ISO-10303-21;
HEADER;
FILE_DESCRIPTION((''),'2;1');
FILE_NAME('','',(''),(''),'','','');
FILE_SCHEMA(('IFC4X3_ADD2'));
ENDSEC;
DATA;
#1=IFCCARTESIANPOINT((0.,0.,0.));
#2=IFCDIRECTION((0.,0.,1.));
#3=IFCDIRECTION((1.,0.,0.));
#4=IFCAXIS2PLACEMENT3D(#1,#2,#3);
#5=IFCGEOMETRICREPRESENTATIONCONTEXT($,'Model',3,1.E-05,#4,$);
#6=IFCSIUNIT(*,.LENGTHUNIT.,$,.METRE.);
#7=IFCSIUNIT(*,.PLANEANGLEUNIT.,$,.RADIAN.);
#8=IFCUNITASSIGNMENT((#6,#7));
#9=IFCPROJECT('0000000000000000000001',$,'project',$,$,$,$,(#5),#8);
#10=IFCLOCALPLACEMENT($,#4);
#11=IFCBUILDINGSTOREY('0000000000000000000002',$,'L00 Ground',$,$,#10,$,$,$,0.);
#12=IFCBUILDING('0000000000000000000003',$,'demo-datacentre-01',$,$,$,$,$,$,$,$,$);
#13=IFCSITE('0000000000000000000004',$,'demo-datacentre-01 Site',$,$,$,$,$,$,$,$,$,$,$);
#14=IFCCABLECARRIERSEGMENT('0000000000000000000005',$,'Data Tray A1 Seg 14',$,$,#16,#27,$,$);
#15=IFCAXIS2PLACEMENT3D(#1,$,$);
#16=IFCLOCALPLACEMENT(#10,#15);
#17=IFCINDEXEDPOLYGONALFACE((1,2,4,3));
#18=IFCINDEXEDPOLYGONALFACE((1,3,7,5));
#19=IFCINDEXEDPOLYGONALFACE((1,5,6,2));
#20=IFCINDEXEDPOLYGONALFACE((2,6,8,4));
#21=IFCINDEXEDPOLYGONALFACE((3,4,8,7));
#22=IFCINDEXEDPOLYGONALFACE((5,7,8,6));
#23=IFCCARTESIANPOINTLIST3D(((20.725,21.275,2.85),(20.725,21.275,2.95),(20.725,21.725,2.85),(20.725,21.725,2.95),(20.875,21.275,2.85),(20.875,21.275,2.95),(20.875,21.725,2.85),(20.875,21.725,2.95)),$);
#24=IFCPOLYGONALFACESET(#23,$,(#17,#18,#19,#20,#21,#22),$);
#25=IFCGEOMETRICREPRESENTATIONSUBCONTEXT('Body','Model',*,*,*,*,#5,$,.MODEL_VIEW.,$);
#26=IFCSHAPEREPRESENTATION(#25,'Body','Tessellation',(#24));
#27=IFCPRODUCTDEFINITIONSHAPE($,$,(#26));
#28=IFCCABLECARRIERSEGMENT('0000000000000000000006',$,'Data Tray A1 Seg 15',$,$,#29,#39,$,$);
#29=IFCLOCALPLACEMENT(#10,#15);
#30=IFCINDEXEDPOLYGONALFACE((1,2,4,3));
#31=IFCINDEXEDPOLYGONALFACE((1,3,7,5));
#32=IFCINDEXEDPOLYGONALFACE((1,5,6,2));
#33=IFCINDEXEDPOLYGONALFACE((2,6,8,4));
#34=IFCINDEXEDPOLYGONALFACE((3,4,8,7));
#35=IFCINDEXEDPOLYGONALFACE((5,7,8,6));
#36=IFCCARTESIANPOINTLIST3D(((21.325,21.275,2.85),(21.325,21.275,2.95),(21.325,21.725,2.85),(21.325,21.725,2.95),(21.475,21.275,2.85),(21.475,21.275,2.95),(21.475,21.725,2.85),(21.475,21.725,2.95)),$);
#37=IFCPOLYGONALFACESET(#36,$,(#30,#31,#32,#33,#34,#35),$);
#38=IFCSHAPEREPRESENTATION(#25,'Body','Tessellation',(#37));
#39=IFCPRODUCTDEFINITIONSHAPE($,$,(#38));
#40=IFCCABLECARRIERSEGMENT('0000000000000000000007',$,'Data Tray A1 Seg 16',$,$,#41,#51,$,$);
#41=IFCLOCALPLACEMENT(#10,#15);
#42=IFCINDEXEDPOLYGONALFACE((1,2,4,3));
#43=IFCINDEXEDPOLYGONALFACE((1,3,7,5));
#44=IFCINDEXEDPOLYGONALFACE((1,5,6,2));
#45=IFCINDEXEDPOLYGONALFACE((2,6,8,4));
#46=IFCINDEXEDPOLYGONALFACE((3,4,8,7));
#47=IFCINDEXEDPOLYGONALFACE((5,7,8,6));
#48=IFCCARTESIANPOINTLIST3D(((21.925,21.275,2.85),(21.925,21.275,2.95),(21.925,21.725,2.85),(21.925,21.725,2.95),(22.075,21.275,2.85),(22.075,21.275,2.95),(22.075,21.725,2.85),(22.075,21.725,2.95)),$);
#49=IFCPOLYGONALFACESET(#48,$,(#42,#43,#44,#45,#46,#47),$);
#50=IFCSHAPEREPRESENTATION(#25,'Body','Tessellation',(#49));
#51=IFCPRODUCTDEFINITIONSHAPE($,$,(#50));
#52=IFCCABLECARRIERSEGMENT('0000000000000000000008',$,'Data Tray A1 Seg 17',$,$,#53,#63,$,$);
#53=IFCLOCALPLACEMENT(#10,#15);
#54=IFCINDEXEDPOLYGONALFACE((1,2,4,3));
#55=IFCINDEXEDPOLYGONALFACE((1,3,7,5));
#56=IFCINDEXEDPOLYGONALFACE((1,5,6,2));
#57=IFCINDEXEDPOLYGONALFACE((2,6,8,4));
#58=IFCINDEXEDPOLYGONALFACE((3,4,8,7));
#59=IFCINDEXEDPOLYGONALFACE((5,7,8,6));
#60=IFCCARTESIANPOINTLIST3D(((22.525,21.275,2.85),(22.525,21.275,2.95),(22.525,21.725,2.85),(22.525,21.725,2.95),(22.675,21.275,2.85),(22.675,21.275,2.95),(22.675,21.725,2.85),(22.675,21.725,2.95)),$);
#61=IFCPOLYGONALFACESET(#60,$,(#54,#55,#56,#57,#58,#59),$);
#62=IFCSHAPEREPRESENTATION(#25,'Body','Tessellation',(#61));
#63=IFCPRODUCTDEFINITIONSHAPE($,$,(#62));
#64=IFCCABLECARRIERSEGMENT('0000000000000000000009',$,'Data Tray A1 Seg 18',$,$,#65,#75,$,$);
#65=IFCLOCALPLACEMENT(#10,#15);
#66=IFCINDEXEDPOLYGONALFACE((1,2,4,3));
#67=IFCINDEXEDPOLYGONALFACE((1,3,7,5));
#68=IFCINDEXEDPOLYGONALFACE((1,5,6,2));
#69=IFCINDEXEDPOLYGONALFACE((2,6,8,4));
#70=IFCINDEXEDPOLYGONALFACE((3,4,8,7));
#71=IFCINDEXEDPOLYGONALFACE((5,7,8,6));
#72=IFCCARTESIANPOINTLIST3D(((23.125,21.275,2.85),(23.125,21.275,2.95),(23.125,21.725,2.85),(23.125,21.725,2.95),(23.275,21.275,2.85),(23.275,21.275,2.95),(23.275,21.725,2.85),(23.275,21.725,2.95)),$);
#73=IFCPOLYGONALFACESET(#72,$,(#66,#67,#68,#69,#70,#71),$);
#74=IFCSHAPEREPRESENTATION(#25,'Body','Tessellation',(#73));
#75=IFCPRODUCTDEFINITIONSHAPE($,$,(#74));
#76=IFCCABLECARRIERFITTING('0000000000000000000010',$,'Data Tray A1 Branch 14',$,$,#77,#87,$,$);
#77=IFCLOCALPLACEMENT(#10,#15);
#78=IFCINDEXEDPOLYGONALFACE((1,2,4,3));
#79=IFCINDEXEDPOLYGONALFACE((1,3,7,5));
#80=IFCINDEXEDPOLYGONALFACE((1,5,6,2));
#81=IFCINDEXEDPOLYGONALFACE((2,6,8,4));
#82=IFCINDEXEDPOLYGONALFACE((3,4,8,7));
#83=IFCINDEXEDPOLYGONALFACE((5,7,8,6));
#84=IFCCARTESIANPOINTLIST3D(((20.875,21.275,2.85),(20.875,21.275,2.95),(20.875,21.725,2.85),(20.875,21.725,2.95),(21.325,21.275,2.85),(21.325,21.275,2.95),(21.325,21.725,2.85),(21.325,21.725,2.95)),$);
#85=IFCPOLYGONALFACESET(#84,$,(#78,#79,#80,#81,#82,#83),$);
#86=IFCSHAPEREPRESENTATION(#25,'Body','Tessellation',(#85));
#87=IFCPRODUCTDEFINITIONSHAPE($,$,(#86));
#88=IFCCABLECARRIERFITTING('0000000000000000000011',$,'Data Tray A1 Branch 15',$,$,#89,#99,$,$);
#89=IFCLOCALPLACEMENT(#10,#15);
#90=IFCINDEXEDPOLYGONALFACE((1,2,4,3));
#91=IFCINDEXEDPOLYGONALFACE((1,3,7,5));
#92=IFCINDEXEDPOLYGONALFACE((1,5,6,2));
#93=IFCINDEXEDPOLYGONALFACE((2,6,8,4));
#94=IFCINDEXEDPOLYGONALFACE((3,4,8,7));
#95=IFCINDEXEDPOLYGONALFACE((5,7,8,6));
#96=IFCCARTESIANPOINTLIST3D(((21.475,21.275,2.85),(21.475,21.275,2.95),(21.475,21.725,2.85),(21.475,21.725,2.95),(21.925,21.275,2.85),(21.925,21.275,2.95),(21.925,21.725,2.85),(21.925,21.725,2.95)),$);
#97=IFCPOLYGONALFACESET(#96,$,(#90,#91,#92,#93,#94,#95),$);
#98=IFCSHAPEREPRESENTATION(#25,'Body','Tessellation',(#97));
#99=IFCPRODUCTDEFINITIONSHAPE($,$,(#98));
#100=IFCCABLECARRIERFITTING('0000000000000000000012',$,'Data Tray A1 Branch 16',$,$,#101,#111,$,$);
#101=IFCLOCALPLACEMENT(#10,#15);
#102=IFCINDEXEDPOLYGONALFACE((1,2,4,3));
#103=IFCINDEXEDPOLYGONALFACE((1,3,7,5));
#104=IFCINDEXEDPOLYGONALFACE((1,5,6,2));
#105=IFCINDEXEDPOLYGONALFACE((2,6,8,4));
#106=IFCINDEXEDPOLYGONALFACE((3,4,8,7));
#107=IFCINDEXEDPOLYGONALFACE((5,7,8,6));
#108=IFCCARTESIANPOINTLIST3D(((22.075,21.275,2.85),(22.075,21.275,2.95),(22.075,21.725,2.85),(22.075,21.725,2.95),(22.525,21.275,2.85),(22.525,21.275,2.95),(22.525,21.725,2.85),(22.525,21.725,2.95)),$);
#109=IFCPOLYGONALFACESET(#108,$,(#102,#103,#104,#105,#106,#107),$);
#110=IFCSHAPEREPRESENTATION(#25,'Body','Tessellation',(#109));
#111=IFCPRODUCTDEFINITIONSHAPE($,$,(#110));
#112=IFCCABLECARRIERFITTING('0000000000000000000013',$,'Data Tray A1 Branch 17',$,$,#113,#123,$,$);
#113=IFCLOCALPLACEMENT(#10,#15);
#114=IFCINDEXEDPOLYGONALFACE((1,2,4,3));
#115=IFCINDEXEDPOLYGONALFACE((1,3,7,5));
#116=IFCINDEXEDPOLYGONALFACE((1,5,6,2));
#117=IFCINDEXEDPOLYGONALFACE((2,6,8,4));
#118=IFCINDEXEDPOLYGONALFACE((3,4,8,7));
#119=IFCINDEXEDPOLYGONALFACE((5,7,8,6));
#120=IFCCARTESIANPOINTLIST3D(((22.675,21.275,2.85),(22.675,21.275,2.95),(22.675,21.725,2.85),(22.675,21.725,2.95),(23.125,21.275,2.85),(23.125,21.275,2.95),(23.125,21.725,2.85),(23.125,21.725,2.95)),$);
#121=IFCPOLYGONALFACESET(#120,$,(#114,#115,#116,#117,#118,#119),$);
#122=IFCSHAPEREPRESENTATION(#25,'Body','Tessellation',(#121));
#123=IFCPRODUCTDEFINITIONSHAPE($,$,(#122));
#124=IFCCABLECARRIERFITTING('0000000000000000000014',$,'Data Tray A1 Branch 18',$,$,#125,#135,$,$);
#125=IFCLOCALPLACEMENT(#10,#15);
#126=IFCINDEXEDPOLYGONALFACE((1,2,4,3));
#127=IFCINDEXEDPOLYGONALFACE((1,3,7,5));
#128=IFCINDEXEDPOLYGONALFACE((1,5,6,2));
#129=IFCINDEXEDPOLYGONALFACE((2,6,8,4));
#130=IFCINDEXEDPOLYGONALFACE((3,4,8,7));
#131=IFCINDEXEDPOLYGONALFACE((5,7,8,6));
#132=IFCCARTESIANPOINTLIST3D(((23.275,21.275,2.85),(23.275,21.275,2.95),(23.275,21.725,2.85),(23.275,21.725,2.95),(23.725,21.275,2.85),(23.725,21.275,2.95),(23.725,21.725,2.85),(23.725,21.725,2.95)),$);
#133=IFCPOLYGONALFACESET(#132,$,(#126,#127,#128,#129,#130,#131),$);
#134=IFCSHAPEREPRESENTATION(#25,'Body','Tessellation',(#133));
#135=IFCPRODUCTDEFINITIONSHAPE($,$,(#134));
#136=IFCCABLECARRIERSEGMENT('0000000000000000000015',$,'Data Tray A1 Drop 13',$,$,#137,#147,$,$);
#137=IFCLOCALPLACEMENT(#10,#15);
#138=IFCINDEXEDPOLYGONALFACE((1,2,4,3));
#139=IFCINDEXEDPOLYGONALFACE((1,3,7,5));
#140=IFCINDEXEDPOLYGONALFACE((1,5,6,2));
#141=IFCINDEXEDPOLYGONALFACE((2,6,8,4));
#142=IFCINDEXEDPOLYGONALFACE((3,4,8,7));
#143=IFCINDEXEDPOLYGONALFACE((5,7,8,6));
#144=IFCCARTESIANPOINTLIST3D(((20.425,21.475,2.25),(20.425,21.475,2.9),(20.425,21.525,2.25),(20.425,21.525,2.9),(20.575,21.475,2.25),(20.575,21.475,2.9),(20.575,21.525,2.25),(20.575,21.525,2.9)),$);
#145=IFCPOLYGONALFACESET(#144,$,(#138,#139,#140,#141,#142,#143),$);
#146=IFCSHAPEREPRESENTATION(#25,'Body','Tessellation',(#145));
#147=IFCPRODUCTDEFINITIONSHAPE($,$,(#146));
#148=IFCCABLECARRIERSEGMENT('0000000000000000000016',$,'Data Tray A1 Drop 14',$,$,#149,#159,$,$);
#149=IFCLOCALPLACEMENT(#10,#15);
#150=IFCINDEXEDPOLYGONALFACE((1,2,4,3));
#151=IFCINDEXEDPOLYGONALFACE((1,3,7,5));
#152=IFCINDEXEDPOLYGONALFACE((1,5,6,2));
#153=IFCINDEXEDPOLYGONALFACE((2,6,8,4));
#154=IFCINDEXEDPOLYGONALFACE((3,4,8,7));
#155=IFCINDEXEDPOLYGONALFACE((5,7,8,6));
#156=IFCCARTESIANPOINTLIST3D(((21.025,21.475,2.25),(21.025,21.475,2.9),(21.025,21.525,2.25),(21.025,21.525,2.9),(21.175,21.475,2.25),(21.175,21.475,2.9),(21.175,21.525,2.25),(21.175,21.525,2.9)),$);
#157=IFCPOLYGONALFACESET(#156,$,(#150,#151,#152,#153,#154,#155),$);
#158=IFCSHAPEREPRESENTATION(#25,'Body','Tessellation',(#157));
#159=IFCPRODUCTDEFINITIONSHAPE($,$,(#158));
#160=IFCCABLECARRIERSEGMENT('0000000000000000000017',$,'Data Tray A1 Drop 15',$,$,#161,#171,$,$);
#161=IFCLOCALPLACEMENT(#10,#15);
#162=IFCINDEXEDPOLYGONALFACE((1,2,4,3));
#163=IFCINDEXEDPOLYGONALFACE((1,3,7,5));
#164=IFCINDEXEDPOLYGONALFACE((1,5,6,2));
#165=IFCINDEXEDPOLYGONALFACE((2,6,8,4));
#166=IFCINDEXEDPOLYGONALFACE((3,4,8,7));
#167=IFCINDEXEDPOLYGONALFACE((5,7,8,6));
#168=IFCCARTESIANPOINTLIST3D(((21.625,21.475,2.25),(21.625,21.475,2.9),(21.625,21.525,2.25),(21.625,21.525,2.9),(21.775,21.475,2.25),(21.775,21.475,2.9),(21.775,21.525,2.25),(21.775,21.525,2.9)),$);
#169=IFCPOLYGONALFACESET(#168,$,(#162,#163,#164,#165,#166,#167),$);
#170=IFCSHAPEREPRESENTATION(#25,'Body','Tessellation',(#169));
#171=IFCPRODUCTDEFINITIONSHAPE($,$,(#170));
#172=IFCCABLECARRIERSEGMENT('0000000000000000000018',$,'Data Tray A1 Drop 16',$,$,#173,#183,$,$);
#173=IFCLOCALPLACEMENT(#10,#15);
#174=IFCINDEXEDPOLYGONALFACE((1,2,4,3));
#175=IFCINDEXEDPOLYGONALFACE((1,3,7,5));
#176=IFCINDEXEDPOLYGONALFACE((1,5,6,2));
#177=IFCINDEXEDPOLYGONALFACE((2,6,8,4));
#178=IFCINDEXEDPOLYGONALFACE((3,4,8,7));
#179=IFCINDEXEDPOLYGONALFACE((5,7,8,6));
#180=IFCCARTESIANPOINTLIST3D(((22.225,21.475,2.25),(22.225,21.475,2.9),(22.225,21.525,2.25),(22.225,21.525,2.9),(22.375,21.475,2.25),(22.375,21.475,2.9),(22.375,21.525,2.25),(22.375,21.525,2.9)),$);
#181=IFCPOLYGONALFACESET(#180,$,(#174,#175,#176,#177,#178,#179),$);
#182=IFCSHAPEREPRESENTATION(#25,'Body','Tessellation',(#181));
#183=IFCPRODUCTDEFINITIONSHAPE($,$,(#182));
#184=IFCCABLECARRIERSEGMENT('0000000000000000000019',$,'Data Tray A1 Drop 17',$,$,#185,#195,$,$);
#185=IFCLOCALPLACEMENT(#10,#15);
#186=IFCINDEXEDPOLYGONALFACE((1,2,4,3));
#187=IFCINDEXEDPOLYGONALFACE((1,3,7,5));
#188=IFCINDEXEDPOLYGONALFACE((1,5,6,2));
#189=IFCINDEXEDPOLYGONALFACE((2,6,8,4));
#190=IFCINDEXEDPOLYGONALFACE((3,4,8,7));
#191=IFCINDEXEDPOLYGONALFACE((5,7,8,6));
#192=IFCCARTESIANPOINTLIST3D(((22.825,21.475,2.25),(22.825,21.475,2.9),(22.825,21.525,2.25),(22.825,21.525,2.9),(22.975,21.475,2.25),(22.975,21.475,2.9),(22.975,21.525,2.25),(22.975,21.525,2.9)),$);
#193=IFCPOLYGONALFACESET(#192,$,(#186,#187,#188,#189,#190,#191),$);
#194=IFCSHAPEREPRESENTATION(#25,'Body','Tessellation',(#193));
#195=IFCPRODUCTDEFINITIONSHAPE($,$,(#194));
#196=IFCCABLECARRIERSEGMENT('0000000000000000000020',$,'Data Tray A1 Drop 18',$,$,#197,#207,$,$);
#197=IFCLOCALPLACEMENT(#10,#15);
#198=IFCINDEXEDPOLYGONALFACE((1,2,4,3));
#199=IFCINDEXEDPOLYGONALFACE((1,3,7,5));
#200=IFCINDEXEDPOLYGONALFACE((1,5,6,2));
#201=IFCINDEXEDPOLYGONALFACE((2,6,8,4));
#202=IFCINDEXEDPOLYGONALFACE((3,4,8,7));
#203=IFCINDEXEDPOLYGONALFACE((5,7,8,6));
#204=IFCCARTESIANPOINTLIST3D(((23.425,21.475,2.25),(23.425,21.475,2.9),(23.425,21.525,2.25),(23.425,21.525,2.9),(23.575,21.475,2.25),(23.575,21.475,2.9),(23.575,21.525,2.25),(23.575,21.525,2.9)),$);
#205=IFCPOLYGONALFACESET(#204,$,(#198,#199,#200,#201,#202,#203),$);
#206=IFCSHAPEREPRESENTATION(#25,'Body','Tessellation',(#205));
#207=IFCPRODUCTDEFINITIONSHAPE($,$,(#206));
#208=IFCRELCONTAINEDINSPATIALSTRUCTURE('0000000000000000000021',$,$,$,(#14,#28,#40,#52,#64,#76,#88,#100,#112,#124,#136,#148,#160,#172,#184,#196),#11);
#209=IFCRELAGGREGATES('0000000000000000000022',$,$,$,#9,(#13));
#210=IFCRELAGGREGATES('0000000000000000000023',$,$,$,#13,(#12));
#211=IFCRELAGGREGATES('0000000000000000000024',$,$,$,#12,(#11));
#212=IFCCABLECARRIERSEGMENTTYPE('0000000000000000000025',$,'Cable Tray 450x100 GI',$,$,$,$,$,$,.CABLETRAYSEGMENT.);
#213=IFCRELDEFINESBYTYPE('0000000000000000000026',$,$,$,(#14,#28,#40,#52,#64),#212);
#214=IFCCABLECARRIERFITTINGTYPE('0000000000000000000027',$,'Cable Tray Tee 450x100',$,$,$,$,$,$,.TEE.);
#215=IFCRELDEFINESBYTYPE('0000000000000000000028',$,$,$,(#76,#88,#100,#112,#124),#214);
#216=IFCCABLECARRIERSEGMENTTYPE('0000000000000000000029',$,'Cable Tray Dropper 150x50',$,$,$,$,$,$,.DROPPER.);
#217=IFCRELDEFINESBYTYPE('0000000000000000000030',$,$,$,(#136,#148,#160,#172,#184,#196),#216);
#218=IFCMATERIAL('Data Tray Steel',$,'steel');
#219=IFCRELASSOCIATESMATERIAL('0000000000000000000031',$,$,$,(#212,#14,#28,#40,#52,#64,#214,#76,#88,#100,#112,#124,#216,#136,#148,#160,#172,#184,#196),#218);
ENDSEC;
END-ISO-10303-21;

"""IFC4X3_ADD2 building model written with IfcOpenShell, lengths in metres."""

from ifc_helpers import new_model, si_unit, frame, origin_with_axes, place, context, subcontext, project, spatial, rectangle, extrude, material, type_object, element, save


model = new_model("IFC4X3_ADD2")

# Units and contexts
model_context = context("Model", 3, precision=1e-05, world=origin_with_axes())
body_context = subcontext(model_context, "Body", "Model", "MODEL_VIEW")
ifc_project = project(units=[si_unit("LENGTHUNIT", "METRE"), si_unit("PLANEANGLEUNIT", "RADIAN")], contexts=[model_context])

# Site, building, storey
site = spatial("IfcSite", under=ifc_project, Name="demo-datacentre-01 Site")
building = spatial("IfcBuilding", under=site, Name="demo-datacentre-01")
storey_placement = place(None, origin_with_axes())
storey = spatial("IfcBuildingStorey", under=building, at=storey_placement, Name="L00 Ground", Elevation=0.0)

# Cable carrier segments
ifc_material_1 = material(Name="Data Tray Steel", Category="steel")
cable_carrier_segment_type_1 = type_object("IfcCableCarrierSegmentType", Name="Cable Tray 450x100 GI", PredefinedType="CABLETRAYSEGMENT", material=ifc_material_1)
for number, where, z_axis, x_axis, name in (
    (1, (20.725, 21.5, 2.9), (1.0, 0.0, 0.0), (0.0, 1.0, 0.0), "Data Tray A1 Seg 14"),
    (2, (21.325, 21.5, 2.9), (1.0, 0.0, 0.0), (0.0, 1.0, 0.0), "Data Tray A1 Seg 15"),
):
    element("IfcCableCarrierSegment", number, at=place(storey_placement, frame(where, z_axis=z_axis, x_axis=x_axis)), inside=storey, type_object=cable_carrier_segment_type_1, material=ifc_material_1, Name=name, context=body_context, shape_type="SweptSolid", body=[
        extrude(rectangle(XDim=0.45, YDim=0.1), origin_with_axes(), (0.0, 0.0, 1.0), 0.15),
    ])
for number, where, z_axis, x_axis, name in (
    (3, (21.925, 21.5, 2.9), (1.0, 0.0, 0.0), (0.0, 1.0, 0.0), "Data Tray A1 Seg 16"),
    (4, (22.525, 21.5, 2.9), (1.0, 0.0, 0.0), (0.0, 1.0, 0.0), "Data Tray A1 Seg 17"),
):
    element("IfcCableCarrierSegment", number, at=place(storey_placement, frame(where, z_axis=z_axis, x_axis=x_axis)), inside=storey, type_object=cable_carrier_segment_type_1, material=ifc_material_1, Name=name, context=body_context, shape_type="SweptSolid", body=[
        extrude(rectangle(XDim=0.45, YDim=0.1), origin_with_axes(), (0.0, 0.0, 1.0), 0.15),
    ])
cable_carrier_segment_placement = place(storey_placement, frame((23.125, 21.5, 2.9), z_axis=(1.0, 0.0, 0.0), x_axis=(0.0, 1.0, 0.0)))
element("IfcCableCarrierSegment", 5, at=cable_carrier_segment_placement, inside=storey, type_object=cable_carrier_segment_type_1, material=ifc_material_1, Name="Data Tray A1 Seg 18", context=body_context, shape_type="SweptSolid", body=[
    extrude(rectangle(XDim=0.45, YDim=0.1), origin_with_axes(), (0.0, 0.0, 1.0), 0.15),
])

# Cable carrier fittings
cable_carrier_fitting_type = type_object("IfcCableCarrierFittingType", Name="Cable Tray Tee 450x100", PredefinedType="TEE", material=ifc_material_1)
for number, where, z_axis, x_axis, name in (
    (6, (21.1, 21.5, 2.85), (0.0, 0.0, 1.0), (1.0, 0.0, 0.0), "Data Tray A1 Branch 14"),
    (7, (21.7, 21.5, 2.85), (0.0, 0.0, 1.0), (1.0, 0.0, 0.0), "Data Tray A1 Branch 15"),
    (8, (22.3, 21.5, 2.85), (0.0, 0.0, 1.0), (1.0, 0.0, 0.0), "Data Tray A1 Branch 16"),
    (9, (22.9, 21.5, 2.85), (0.0, 0.0, 1.0), (1.0, 0.0, 0.0), "Data Tray A1 Branch 17"),
    (10, (23.5, 21.5, 2.85), (0.0, 0.0, 1.0), (1.0, 0.0, 0.0), "Data Tray A1 Branch 18"),
):
    element("IfcCableCarrierFitting", number, at=place(storey_placement, frame(where, z_axis=z_axis, x_axis=x_axis)), inside=storey, type_object=cable_carrier_fitting_type, material=ifc_material_1, Name=name, context=body_context, shape_type="SweptSolid", body=[
        extrude(rectangle(XDim=0.45, YDim=0.45), origin_with_axes(), (0.0, 0.0, 1.0), 0.1),
    ])

# Cable carrier segments
cable_carrier_segment_type_2 = type_object("IfcCableCarrierSegmentType", Name="Cable Tray Dropper 150x50", PredefinedType="DROPPER", material=ifc_material_1)
for number, where, z_axis, x_axis, name in (
    (11, (20.5, 21.5, 2.9), (0.0, 0.0, -1.0), (1.0, 0.0, 0.0), "Data Tray A1 Drop 13"),
    (12, (21.1, 21.5, 2.9), (0.0, 0.0, -1.0), (1.0, 0.0, 0.0), "Data Tray A1 Drop 14"),
    (13, (21.7, 21.5, 2.9), (0.0, 0.0, -1.0), (1.0, 0.0, 0.0), "Data Tray A1 Drop 15"),
    (14, (22.3, 21.5, 2.9), (0.0, 0.0, -1.0), (1.0, 0.0, 0.0), "Data Tray A1 Drop 16"),
    (15, (22.9, 21.5, 2.9), (0.0, 0.0, -1.0), (1.0, 0.0, 0.0), "Data Tray A1 Drop 17"),
    (16, (23.5, 21.5, 2.9), (0.0, 0.0, -1.0), (1.0, 0.0, 0.0), "Data Tray A1 Drop 18"),
):
    element("IfcCableCarrierSegment", number, at=place(storey_placement, frame(where, z_axis=z_axis, x_axis=x_axis)), inside=storey, type_object=cable_carrier_segment_type_2, material=ifc_material_1, Name=name, context=body_context, shape_type="SweptSolid", body=[
        extrude(rectangle(XDim=0.15, YDim=0.05), origin_with_axes(), (0.0, 0.0, 1.0), 0.65),
    ])

save(model, "model.ifc")
